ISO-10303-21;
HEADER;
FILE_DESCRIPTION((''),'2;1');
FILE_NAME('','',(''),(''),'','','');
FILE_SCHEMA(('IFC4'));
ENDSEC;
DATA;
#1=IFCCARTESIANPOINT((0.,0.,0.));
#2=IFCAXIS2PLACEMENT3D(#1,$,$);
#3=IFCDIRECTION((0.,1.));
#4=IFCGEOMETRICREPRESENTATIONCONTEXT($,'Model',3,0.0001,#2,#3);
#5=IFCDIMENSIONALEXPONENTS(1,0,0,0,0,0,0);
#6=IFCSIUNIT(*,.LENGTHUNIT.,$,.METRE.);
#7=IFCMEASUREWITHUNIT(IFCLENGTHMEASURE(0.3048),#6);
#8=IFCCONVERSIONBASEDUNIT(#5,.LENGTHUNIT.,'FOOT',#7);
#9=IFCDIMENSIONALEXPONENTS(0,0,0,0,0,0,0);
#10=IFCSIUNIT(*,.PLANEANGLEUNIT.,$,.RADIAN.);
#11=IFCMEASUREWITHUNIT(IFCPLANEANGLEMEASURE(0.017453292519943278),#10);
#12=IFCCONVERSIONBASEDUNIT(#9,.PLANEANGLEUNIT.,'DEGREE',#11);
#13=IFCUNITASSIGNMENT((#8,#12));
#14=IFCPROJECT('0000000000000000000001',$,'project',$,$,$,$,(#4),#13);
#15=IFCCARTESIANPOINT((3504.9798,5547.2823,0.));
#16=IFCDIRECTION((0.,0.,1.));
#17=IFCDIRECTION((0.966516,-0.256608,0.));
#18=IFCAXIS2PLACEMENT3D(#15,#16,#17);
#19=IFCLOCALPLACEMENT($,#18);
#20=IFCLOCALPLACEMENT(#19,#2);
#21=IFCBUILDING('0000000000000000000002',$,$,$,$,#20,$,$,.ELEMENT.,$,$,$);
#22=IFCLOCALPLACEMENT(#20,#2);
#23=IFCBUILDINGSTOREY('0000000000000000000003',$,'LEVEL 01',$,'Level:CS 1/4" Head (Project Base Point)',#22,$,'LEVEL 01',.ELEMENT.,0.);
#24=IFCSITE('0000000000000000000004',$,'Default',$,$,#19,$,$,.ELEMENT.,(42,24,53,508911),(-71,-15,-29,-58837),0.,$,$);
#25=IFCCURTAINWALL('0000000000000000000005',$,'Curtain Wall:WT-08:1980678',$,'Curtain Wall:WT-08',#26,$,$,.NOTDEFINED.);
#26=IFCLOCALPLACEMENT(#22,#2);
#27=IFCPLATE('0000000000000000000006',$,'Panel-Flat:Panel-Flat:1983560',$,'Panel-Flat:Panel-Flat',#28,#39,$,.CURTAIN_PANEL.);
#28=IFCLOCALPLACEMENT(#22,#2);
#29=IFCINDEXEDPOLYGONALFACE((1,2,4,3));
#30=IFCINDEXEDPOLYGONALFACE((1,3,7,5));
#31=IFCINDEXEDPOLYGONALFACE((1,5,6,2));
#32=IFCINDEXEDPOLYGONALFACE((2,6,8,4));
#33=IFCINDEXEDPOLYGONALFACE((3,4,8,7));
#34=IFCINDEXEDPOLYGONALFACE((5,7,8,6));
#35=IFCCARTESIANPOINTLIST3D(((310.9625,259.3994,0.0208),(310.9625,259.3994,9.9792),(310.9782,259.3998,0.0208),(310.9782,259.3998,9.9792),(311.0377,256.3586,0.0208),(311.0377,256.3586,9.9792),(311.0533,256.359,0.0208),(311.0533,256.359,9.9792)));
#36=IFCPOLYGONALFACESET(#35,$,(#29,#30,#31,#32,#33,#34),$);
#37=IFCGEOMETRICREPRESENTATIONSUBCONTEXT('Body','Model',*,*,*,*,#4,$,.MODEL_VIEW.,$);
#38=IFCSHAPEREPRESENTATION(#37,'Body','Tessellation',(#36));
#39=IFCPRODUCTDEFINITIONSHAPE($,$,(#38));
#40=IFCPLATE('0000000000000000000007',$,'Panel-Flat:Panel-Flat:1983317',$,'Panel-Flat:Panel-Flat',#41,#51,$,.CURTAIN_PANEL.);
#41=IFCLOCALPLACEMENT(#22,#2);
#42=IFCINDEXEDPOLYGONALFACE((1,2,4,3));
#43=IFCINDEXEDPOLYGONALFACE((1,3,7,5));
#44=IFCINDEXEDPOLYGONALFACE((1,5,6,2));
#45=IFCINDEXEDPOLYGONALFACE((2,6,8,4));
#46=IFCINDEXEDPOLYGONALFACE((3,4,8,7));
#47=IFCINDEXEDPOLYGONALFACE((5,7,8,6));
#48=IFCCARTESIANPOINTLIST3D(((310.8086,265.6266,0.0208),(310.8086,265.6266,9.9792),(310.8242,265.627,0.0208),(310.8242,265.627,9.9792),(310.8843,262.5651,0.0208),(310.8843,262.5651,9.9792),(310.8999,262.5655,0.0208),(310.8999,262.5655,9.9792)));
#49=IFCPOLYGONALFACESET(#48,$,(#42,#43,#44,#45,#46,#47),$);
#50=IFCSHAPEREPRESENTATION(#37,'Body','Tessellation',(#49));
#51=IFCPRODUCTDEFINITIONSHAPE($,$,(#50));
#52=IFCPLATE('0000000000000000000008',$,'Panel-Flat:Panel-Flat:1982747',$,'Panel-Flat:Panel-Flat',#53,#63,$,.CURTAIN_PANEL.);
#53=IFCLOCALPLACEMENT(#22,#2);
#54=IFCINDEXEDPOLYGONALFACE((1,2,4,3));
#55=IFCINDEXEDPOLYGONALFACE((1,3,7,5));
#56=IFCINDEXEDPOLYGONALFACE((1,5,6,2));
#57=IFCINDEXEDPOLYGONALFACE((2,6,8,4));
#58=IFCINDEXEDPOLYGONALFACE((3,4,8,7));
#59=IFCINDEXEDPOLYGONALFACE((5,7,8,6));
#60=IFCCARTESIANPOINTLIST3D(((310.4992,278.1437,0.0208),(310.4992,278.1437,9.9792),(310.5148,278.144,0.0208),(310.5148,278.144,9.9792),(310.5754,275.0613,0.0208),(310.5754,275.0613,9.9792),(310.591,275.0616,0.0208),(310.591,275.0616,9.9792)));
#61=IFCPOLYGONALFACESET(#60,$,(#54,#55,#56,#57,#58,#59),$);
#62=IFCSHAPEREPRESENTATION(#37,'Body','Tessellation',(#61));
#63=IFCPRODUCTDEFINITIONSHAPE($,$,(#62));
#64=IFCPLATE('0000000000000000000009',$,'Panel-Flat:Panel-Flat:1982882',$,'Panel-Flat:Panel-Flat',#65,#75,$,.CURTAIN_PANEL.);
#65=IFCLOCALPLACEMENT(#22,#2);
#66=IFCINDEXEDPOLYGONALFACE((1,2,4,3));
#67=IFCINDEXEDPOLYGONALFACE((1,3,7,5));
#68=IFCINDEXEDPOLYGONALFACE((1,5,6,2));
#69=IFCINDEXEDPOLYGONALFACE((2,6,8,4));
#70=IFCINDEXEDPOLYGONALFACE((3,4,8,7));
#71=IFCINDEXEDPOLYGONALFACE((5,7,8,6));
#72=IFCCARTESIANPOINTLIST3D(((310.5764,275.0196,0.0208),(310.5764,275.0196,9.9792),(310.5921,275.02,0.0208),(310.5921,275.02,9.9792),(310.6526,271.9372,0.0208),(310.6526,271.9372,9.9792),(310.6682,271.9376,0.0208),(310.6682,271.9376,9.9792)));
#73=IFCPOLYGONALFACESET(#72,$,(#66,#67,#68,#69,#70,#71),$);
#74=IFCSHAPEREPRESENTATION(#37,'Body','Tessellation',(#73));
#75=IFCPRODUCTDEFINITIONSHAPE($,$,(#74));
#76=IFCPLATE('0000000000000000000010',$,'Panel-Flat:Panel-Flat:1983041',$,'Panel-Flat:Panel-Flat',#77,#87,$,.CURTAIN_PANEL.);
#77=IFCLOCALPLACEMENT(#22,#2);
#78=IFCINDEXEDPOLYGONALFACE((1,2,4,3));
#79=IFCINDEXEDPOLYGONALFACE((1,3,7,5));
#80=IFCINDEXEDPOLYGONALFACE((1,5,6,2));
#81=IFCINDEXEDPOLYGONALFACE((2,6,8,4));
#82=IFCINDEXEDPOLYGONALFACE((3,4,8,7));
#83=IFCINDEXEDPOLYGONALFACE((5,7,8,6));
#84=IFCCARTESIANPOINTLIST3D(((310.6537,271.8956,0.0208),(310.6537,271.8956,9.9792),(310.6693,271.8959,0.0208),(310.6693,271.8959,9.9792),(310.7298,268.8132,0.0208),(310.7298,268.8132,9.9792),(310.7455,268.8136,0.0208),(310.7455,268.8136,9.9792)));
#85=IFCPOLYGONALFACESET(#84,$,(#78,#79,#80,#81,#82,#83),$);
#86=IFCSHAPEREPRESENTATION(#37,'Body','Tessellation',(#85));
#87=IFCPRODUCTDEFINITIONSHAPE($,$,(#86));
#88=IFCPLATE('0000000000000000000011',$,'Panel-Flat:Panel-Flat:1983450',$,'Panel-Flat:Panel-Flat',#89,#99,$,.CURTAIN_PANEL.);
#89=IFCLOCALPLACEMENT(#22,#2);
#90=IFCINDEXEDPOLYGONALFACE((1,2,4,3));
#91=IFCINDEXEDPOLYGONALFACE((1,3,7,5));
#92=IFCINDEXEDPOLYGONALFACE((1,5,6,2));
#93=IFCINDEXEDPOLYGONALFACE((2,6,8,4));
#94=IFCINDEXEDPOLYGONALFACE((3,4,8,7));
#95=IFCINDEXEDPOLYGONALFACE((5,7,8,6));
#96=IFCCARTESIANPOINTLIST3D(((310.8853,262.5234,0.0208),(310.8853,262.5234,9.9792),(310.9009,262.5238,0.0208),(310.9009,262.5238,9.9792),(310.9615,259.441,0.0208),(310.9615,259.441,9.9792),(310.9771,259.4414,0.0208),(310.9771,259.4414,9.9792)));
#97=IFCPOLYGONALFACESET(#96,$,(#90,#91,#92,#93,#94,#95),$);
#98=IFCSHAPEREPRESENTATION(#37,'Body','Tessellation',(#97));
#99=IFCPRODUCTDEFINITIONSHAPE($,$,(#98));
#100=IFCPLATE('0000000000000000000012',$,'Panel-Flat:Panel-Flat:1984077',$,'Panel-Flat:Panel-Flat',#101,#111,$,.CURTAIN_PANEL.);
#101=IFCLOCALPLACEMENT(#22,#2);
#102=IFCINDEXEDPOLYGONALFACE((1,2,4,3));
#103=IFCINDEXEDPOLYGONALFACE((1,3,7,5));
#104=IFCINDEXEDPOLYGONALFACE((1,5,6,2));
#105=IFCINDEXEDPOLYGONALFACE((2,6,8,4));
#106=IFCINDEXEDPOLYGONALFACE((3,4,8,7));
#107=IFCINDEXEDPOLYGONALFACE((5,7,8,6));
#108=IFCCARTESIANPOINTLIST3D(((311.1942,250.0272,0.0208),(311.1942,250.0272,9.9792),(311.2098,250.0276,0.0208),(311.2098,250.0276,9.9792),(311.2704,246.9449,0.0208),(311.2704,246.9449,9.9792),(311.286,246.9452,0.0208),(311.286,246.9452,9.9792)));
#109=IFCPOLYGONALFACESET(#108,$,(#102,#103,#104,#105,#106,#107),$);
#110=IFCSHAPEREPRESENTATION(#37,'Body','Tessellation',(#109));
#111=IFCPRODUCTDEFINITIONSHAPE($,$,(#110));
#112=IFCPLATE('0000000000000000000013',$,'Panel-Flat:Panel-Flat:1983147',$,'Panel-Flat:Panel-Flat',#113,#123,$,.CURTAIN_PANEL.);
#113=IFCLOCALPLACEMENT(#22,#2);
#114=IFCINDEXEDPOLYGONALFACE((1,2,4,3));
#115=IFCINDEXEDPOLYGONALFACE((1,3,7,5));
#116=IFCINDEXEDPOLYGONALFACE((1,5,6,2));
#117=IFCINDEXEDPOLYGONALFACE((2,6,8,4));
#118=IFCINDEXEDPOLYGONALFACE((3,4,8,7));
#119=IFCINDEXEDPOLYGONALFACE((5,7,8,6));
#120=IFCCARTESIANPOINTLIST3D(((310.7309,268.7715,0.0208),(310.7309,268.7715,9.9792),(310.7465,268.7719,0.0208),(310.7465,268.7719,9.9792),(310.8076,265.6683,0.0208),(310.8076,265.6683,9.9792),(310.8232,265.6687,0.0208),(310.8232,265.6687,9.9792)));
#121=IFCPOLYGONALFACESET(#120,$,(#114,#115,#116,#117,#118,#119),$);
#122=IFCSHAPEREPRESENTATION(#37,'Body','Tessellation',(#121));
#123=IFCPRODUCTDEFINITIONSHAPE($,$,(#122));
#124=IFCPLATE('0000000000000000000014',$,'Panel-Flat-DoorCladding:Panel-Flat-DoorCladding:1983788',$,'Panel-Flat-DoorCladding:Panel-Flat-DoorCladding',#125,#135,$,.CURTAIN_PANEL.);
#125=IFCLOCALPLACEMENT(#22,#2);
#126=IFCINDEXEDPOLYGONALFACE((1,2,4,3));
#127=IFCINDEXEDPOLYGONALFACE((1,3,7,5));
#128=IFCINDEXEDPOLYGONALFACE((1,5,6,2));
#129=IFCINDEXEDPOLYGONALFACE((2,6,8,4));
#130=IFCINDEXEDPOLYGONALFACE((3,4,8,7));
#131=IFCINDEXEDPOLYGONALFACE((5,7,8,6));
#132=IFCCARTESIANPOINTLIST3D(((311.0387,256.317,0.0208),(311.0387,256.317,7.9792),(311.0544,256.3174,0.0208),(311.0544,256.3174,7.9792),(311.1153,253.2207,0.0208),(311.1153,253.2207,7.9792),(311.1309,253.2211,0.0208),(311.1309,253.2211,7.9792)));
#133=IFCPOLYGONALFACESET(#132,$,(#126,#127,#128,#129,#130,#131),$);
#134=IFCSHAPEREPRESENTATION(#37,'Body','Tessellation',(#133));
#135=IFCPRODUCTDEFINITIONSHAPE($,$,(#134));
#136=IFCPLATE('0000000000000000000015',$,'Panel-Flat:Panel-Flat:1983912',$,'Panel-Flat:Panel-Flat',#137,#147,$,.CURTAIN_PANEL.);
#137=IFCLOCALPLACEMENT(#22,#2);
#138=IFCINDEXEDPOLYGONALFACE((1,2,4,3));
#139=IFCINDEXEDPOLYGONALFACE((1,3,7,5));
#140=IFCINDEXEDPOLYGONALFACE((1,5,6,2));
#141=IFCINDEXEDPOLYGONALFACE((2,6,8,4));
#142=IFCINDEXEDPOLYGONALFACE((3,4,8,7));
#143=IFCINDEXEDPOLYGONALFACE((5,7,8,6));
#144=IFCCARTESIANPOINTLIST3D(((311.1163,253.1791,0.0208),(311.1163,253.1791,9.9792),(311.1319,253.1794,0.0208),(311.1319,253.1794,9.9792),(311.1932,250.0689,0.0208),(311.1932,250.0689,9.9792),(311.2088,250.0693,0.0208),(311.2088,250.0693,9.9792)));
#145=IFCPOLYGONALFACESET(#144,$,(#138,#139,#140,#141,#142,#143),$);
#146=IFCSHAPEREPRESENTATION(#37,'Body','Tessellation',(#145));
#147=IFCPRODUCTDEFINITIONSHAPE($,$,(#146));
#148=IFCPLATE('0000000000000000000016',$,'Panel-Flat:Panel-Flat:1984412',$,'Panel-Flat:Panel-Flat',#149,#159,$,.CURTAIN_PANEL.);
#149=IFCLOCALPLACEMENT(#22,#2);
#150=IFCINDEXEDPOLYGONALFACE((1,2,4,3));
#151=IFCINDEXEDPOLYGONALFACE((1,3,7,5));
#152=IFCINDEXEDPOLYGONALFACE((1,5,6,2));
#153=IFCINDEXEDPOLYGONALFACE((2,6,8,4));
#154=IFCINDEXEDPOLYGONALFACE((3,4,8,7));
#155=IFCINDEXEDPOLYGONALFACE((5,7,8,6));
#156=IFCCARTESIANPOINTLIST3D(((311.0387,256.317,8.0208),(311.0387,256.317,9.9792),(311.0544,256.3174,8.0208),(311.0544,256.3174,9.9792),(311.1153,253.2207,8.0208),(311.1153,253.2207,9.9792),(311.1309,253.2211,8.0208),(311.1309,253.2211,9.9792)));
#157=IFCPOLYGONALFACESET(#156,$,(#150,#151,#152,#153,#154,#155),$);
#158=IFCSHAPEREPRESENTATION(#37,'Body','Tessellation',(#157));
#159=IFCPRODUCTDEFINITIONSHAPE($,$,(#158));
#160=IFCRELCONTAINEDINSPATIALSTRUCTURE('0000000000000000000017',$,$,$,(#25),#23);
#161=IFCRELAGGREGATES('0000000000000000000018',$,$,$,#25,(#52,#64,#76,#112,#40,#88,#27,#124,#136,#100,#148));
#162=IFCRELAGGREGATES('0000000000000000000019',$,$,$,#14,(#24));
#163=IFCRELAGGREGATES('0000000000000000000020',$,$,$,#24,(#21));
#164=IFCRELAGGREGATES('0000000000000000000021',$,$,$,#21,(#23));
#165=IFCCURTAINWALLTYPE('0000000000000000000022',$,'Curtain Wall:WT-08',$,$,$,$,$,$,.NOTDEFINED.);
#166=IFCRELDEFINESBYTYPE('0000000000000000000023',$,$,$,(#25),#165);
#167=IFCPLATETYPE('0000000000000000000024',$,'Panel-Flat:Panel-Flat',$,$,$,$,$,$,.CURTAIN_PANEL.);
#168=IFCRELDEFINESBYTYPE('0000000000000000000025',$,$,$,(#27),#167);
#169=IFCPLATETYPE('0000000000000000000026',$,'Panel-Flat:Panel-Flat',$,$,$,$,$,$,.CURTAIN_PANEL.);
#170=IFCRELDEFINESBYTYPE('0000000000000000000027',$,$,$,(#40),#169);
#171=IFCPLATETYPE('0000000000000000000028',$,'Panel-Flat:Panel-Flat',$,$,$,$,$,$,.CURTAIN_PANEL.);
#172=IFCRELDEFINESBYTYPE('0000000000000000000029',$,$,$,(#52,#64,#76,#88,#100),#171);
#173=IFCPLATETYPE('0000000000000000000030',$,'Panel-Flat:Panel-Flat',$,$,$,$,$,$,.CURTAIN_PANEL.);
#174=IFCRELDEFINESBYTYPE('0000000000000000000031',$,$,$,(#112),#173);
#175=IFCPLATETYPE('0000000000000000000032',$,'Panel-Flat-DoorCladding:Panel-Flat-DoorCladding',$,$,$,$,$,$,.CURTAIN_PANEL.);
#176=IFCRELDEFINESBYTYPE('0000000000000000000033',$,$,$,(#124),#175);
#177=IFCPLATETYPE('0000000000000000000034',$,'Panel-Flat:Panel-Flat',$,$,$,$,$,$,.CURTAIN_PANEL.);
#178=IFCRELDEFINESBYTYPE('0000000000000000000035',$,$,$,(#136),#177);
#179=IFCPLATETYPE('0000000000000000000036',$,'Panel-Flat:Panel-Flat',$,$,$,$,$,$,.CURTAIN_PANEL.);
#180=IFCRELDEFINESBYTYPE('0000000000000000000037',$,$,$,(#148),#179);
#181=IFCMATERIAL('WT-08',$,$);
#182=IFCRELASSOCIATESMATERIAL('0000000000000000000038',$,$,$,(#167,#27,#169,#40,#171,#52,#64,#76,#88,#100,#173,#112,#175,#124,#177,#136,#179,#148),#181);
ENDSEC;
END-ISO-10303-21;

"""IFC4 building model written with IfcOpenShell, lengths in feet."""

from ifc_helpers import new_model, entity, si_unit, converted_unit, direction, frame, origin, place, context, subcontext, project, spatial, indexed_curve, outline, extrude, source, transform, mapped, material, type_object, type_shapes, element, aggregate, save


model = new_model("IFC4")

# Units and contexts
model_context = context("Model", 3, precision=0.0001, world=origin(), true_north=direction((0.0, 1.0)))
body_context = subcontext(model_context, "Body", "Model", "MODEL_VIEW")
ifc_project = project(units=[converted_unit("LENGTHUNIT", "FOOT", entity("IfcLengthMeasure", 0.3048), si_unit("LENGTHUNIT", "METRE"), dimensions=[1, 0, 0, 0, 0, 0, 0]), converted_unit("PLANEANGLEUNIT", "DEGREE", entity("IfcPlaneAngleMeasure", 0.017453292519943278), si_unit("PLANEANGLEUNIT", "RADIAN"), dimensions=[0, 0, 0, 0, 0, 0, 0])], contexts=[model_context])

# Site, building, storey
site_placement = place(None, frame((3504.9798, 5547.2823, 0.0), z_axis=(0.0, 0.0, 1.0), x_axis=(0.966516, -0.256608, 0.0)))
site = spatial("IfcSite", under=ifc_project, at=site_placement, Name="Default", CompositionType="ELEMENT", RefLatitude=(42, 24, 53, 508911), RefLongitude=(-71, -15, -29, -58837), RefElevation=0.0)
building_placement = place(site_placement, origin())
building = spatial("IfcBuilding", under=site, at=building_placement, CompositionType="ELEMENT")
storey_placement = place(building_placement, origin())
storey = spatial("IfcBuildingStorey", under=building, at=storey_placement, Name="LEVEL 01", ObjectType="Level:CS 1/4\" Head (Project Base Point)", LongName="LEVEL 01", CompositionType="ELEMENT", Elevation=0.0)

# Curtain wall, plates
curtain_wall_type_1 = type_object("IfcCurtainWallType", Name="Curtain Wall:WT-08", PredefinedType="NOTDEFINED")
curtain_wall_1_placement = place(storey_placement, origin())
curtain_wall_1 = element("IfcCurtainWall", 1, at=curtain_wall_1_placement, inside=storey, type_object=curtain_wall_type_1, Name="Curtain Wall:WT-08:1980678", ObjectType="Curtain Wall:WT-08", PredefinedType="NOTDEFINED")
ifc_material_1 = material(Name="WT-08")
plate_type_1 = type_object("IfcPlateType", Name="Panel-Flat:Panel-Flat", PredefinedType="CURTAIN_PANEL", material=ifc_material_1)
shared_shape_1 = source(origin(), body_context, "Body", "SweptSolid", [
    extrude(outline(indexed_curve([(-0.0078, -1.5208), (0.0078, -1.5208), (0.0078, 1.5208), (-0.0078, 1.5208), (-0.0078, -1.5208)], self_intersect=False)), frame((1.5208, 0.0078, 0.0), z_axis=(0.0, 0.0, 1.0), x_axis=(0.0, -1.0, 0.0)), (0.0, 0.0, 1.0), 9.9583),
])
type_shapes(plate_type_1, [shared_shape_1])
plate_1_placement = place(curtain_wall_1_placement, frame((310.9625, 259.3994, 0.0208), z_axis=(0.0, 0.0, 1.0), x_axis=(0.024711, -0.999695, 0.0)))
plate_1 = element("IfcPlate", 2, at=plate_1_placement, type_object=plate_type_1, material=ifc_material_1, Name="Panel-Flat:Panel-Flat:1983560", ObjectType="Panel-Flat:Panel-Flat", PredefinedType="CURTAIN_PANEL", context=body_context, shape_type="MappedRepresentation", body=[
    mapped(shared_shape_1, transform((0.0, 0.0, 0.0), scale=1.0)),
])
plate_type_2 = type_object("IfcPlateType", Name="Panel-Flat:Panel-Flat", PredefinedType="CURTAIN_PANEL", material=ifc_material_1)
shared_shape_2 = source(origin(), body_context, "Body", "SweptSolid", [
    extrude(outline(indexed_curve([(-0.0078, -1.5313), (0.0078, -1.5313), (0.0078, 1.5313), (-0.0078, 1.5313), (-0.0078, -1.5313)], self_intersect=False)), frame((1.5313, 0.0078, 0.0), z_axis=(0.0, 0.0, 1.0), x_axis=(0.0, -1.0, 0.0)), (0.0, 0.0, 1.0), 9.9583),
])
type_shapes(plate_type_2, [shared_shape_2])
plate_2_placement = place(curtain_wall_1_placement, frame((310.8086, 265.6266, 0.0208), z_axis=(0.0, 0.0, 1.0), x_axis=(0.024711, -0.999695, 0.0)))
plate_2 = element("IfcPlate", 3, at=plate_2_placement, type_object=plate_type_2, material=ifc_material_1, Name="Panel-Flat:Panel-Flat:1983317", ObjectType="Panel-Flat:Panel-Flat", PredefinedType="CURTAIN_PANEL", context=body_context, shape_type="MappedRepresentation", body=[
    mapped(shared_shape_2, transform((0.0, 0.0, 0.0), scale=1.0)),
])
plate_type_3 = type_object("IfcPlateType", Name="Panel-Flat:Panel-Flat", PredefinedType="CURTAIN_PANEL", material=ifc_material_1)
shared_shape_3 = source(origin(), body_context, "Body", "SweptSolid", [
    extrude(outline(indexed_curve([(-0.0078, -1.5417), (0.0078, -1.5417), (0.0078, 1.5417), (-0.0078, 1.5417), (-0.0078, -1.5417)], self_intersect=False)), frame((1.5417, 0.0078, 0.0), z_axis=(0.0, 0.0, 1.0), x_axis=(0.0, -1.0, 0.0)), (0.0, 0.0, 1.0), 9.9583),
])
type_shapes(plate_type_3, [shared_shape_3])
plate_3_placement = place(curtain_wall_1_placement, frame((310.4992, 278.1437, 0.0208), z_axis=(0.0, 0.0, 1.0), x_axis=(0.024711, -0.999695, 0.0)))
plate_3 = element("IfcPlate", 4, at=plate_3_placement, type_object=plate_type_3, material=ifc_material_1, Name="Panel-Flat:Panel-Flat:1982747", ObjectType="Panel-Flat:Panel-Flat", PredefinedType="CURTAIN_PANEL", context=body_context, shape_type="MappedRepresentation", body=[
    mapped(shared_shape_3, transform((0.0, 0.0, 0.0), scale=1.0)),
])
plate_4_placement = place(curtain_wall_1_placement, frame((310.5764, 275.0196, 0.0208), z_axis=(0.0, 0.0, 1.0), x_axis=(0.024711, -0.999695, 0.0)))
plate_4 = element("IfcPlate", 5, at=plate_4_placement, type_object=plate_type_3, material=ifc_material_1, Name="Panel-Flat:Panel-Flat:1982882", ObjectType="Panel-Flat:Panel-Flat", PredefinedType="CURTAIN_PANEL", context=body_context, shape_type="MappedRepresentation", body=[
    mapped(shared_shape_3, transform((0.0, 0.0, 0.0), scale=1.0)),
])
plate_5_placement = place(curtain_wall_1_placement, frame((310.6537, 271.8956, 0.0208), z_axis=(0.0, 0.0, 1.0), x_axis=(0.024711, -0.999695, 0.0)))
plate_5 = element("IfcPlate", 6, at=plate_5_placement, type_object=plate_type_3, material=ifc_material_1, Name="Panel-Flat:Panel-Flat:1983041", ObjectType="Panel-Flat:Panel-Flat", PredefinedType="CURTAIN_PANEL", context=body_context, shape_type="MappedRepresentation", body=[
    mapped(shared_shape_3, transform((0.0, 0.0, 0.0), scale=1.0)),
])
plate_6_placement = place(curtain_wall_1_placement, frame((310.8853, 262.5234, 0.0208), z_axis=(0.0, 0.0, 1.0), x_axis=(0.024711, -0.999695, 0.0)))
plate_6 = element("IfcPlate", 7, at=plate_6_placement, type_object=plate_type_3, material=ifc_material_1, Name="Panel-Flat:Panel-Flat:1983450", ObjectType="Panel-Flat:Panel-Flat", PredefinedType="CURTAIN_PANEL", context=body_context, shape_type="MappedRepresentation", body=[
    mapped(shared_shape_3, transform((0.0, 0.0, 0.0), scale=1.0)),
])
plate_7_placement = place(curtain_wall_1_placement, frame((311.1942, 250.0272, 0.0208), z_axis=(0.0, 0.0, 1.0), x_axis=(0.024711, -0.999695, 0.0)))
plate_7 = element("IfcPlate", 8, at=plate_7_placement, type_object=plate_type_3, material=ifc_material_1, Name="Panel-Flat:Panel-Flat:1984077", ObjectType="Panel-Flat:Panel-Flat", PredefinedType="CURTAIN_PANEL", context=body_context, shape_type="MappedRepresentation", body=[
    mapped(shared_shape_3, transform((0.0, 0.0, 0.0), scale=1.0)),
])
plate_type_4 = type_object("IfcPlateType", Name="Panel-Flat:Panel-Flat", PredefinedType="CURTAIN_PANEL", material=ifc_material_1)
shared_shape_4 = source(origin(), body_context, "Body", "SweptSolid", [
    extrude(outline(indexed_curve([(-0.0078, -1.5521), (0.0078, -1.5521), (0.0078, 1.5521), (-0.0078, 1.5521), (-0.0078, -1.5521)], self_intersect=False)), frame((1.5521, 0.0078, 0.0), z_axis=(0.0, 0.0, 1.0), x_axis=(0.0, -1.0, 0.0)), (0.0, 0.0, 1.0), 9.9583),
])
type_shapes(plate_type_4, [shared_shape_4])
plate_8_placement = place(curtain_wall_1_placement, frame((310.7309, 268.7715, 0.0208), z_axis=(0.0, 0.0, 1.0), x_axis=(0.024711, -0.999695, 0.0)))
plate_8 = element("IfcPlate", 9, at=plate_8_placement, type_object=plate_type_4, material=ifc_material_1, Name="Panel-Flat:Panel-Flat:1983147", ObjectType="Panel-Flat:Panel-Flat", PredefinedType="CURTAIN_PANEL", context=body_context, shape_type="MappedRepresentation", body=[
    mapped(shared_shape_4, transform((0.0, 0.0, 0.0), scale=1.0)),
])
plate_type_5 = type_object("IfcPlateType", Name="Panel-Flat-DoorCladding:Panel-Flat-DoorCladding", PredefinedType="CURTAIN_PANEL", material=ifc_material_1)
shared_shape_5 = source(origin(), body_context, "Body", "SweptSolid", [
    extrude(outline(indexed_curve([(-0.0078, -1.5486), (0.0078, -1.5486), (0.0078, 1.5486), (-0.0078, 1.5486), (-0.0078, -1.5486)], self_intersect=False)), frame((1.5486, 0.0078, 0.0), z_axis=(0.0, 0.0, 1.0), x_axis=(0.0, -1.0, 0.0)), (0.0, 0.0, 1.0), 7.9583),
])
type_shapes(plate_type_5, [shared_shape_5])
plate_9_placement = place(curtain_wall_1_placement, frame((311.0387, 256.317, 0.0208), z_axis=(0.0, 0.0, 1.0), x_axis=(0.024711, -0.999695, 0.0)))
plate_9 = element("IfcPlate", 10, at=plate_9_placement, type_object=plate_type_5, material=ifc_material_1, Name="Panel-Flat-DoorCladding:Panel-Flat-DoorCladding:1983788", ObjectType="Panel-Flat-DoorCladding:Panel-Flat-DoorCladding", PredefinedType="CURTAIN_PANEL", context=body_context, shape_type="MappedRepresentation", body=[
    mapped(shared_shape_5, transform((0.0, 0.0, 0.0), scale=1.0)),
])
plate_type_6 = type_object("IfcPlateType", Name="Panel-Flat:Panel-Flat", PredefinedType="CURTAIN_PANEL", material=ifc_material_1)
shared_shape_6 = source(origin(), body_context, "Body", "SweptSolid", [
    extrude(outline(indexed_curve([(-0.0078, -1.5556), (0.0078, -1.5556), (0.0078, 1.5556), (-0.0078, 1.5556), (-0.0078, -1.5556)], self_intersect=False)), frame((1.5556, 0.0078, 0.0), z_axis=(0.0, 0.0, 1.0), x_axis=(0.0, -1.0, 0.0)), (0.0, 0.0, 1.0), 9.9583),
])
type_shapes(plate_type_6, [shared_shape_6])
plate_10_placement = place(curtain_wall_1_placement, frame((311.1163, 253.1791, 0.0208), z_axis=(0.0, 0.0, 1.0), x_axis=(0.024711, -0.999695, 0.0)))
plate_10 = element("IfcPlate", 11, at=plate_10_placement, type_object=plate_type_6, material=ifc_material_1, Name="Panel-Flat:Panel-Flat:1983912", ObjectType="Panel-Flat:Panel-Flat", PredefinedType="CURTAIN_PANEL", context=body_context, shape_type="MappedRepresentation", body=[
    mapped(shared_shape_6, transform((0.0, 0.0, 0.0), scale=1.0)),
])
plate_type_7 = type_object("IfcPlateType", Name="Panel-Flat:Panel-Flat", PredefinedType="CURTAIN_PANEL", material=ifc_material_1)
shared_shape_7 = source(origin(), body_context, "Body", "SweptSolid", [
    extrude(outline(indexed_curve([(-0.0078, -1.5486), (0.0078, -1.5486), (0.0078, 1.5486), (-0.0078, 1.5486), (-0.0078, -1.5486)], self_intersect=False)), frame((1.5486, 0.0078, 0.0), z_axis=(0.0, 0.0, 1.0), x_axis=(0.0, -1.0, 0.0)), (0.0, 0.0, 1.0), 1.9583),
])
type_shapes(plate_type_7, [shared_shape_7])
plate_11_placement = place(curtain_wall_1_placement, frame((311.0387, 256.317, 8.0208), z_axis=(0.0, 0.0, 1.0), x_axis=(0.024711, -0.999695, 0.0)))
plate_11 = element("IfcPlate", 12, at=plate_11_placement, type_object=plate_type_7, material=ifc_material_1, Name="Panel-Flat:Panel-Flat:1984412", ObjectType="Panel-Flat:Panel-Flat", PredefinedType="CURTAIN_PANEL", context=body_context, shape_type="MappedRepresentation", body=[
    mapped(shared_shape_7, transform((0.0, 0.0, 0.0), scale=1.0)),
])

aggregate(curtain_wall_1, [plate_3, plate_4, plate_5, plate_8, plate_2, plate_6, plate_1, plate_9, plate_10, plate_7, plate_11])

save(model, "model.ifc")
